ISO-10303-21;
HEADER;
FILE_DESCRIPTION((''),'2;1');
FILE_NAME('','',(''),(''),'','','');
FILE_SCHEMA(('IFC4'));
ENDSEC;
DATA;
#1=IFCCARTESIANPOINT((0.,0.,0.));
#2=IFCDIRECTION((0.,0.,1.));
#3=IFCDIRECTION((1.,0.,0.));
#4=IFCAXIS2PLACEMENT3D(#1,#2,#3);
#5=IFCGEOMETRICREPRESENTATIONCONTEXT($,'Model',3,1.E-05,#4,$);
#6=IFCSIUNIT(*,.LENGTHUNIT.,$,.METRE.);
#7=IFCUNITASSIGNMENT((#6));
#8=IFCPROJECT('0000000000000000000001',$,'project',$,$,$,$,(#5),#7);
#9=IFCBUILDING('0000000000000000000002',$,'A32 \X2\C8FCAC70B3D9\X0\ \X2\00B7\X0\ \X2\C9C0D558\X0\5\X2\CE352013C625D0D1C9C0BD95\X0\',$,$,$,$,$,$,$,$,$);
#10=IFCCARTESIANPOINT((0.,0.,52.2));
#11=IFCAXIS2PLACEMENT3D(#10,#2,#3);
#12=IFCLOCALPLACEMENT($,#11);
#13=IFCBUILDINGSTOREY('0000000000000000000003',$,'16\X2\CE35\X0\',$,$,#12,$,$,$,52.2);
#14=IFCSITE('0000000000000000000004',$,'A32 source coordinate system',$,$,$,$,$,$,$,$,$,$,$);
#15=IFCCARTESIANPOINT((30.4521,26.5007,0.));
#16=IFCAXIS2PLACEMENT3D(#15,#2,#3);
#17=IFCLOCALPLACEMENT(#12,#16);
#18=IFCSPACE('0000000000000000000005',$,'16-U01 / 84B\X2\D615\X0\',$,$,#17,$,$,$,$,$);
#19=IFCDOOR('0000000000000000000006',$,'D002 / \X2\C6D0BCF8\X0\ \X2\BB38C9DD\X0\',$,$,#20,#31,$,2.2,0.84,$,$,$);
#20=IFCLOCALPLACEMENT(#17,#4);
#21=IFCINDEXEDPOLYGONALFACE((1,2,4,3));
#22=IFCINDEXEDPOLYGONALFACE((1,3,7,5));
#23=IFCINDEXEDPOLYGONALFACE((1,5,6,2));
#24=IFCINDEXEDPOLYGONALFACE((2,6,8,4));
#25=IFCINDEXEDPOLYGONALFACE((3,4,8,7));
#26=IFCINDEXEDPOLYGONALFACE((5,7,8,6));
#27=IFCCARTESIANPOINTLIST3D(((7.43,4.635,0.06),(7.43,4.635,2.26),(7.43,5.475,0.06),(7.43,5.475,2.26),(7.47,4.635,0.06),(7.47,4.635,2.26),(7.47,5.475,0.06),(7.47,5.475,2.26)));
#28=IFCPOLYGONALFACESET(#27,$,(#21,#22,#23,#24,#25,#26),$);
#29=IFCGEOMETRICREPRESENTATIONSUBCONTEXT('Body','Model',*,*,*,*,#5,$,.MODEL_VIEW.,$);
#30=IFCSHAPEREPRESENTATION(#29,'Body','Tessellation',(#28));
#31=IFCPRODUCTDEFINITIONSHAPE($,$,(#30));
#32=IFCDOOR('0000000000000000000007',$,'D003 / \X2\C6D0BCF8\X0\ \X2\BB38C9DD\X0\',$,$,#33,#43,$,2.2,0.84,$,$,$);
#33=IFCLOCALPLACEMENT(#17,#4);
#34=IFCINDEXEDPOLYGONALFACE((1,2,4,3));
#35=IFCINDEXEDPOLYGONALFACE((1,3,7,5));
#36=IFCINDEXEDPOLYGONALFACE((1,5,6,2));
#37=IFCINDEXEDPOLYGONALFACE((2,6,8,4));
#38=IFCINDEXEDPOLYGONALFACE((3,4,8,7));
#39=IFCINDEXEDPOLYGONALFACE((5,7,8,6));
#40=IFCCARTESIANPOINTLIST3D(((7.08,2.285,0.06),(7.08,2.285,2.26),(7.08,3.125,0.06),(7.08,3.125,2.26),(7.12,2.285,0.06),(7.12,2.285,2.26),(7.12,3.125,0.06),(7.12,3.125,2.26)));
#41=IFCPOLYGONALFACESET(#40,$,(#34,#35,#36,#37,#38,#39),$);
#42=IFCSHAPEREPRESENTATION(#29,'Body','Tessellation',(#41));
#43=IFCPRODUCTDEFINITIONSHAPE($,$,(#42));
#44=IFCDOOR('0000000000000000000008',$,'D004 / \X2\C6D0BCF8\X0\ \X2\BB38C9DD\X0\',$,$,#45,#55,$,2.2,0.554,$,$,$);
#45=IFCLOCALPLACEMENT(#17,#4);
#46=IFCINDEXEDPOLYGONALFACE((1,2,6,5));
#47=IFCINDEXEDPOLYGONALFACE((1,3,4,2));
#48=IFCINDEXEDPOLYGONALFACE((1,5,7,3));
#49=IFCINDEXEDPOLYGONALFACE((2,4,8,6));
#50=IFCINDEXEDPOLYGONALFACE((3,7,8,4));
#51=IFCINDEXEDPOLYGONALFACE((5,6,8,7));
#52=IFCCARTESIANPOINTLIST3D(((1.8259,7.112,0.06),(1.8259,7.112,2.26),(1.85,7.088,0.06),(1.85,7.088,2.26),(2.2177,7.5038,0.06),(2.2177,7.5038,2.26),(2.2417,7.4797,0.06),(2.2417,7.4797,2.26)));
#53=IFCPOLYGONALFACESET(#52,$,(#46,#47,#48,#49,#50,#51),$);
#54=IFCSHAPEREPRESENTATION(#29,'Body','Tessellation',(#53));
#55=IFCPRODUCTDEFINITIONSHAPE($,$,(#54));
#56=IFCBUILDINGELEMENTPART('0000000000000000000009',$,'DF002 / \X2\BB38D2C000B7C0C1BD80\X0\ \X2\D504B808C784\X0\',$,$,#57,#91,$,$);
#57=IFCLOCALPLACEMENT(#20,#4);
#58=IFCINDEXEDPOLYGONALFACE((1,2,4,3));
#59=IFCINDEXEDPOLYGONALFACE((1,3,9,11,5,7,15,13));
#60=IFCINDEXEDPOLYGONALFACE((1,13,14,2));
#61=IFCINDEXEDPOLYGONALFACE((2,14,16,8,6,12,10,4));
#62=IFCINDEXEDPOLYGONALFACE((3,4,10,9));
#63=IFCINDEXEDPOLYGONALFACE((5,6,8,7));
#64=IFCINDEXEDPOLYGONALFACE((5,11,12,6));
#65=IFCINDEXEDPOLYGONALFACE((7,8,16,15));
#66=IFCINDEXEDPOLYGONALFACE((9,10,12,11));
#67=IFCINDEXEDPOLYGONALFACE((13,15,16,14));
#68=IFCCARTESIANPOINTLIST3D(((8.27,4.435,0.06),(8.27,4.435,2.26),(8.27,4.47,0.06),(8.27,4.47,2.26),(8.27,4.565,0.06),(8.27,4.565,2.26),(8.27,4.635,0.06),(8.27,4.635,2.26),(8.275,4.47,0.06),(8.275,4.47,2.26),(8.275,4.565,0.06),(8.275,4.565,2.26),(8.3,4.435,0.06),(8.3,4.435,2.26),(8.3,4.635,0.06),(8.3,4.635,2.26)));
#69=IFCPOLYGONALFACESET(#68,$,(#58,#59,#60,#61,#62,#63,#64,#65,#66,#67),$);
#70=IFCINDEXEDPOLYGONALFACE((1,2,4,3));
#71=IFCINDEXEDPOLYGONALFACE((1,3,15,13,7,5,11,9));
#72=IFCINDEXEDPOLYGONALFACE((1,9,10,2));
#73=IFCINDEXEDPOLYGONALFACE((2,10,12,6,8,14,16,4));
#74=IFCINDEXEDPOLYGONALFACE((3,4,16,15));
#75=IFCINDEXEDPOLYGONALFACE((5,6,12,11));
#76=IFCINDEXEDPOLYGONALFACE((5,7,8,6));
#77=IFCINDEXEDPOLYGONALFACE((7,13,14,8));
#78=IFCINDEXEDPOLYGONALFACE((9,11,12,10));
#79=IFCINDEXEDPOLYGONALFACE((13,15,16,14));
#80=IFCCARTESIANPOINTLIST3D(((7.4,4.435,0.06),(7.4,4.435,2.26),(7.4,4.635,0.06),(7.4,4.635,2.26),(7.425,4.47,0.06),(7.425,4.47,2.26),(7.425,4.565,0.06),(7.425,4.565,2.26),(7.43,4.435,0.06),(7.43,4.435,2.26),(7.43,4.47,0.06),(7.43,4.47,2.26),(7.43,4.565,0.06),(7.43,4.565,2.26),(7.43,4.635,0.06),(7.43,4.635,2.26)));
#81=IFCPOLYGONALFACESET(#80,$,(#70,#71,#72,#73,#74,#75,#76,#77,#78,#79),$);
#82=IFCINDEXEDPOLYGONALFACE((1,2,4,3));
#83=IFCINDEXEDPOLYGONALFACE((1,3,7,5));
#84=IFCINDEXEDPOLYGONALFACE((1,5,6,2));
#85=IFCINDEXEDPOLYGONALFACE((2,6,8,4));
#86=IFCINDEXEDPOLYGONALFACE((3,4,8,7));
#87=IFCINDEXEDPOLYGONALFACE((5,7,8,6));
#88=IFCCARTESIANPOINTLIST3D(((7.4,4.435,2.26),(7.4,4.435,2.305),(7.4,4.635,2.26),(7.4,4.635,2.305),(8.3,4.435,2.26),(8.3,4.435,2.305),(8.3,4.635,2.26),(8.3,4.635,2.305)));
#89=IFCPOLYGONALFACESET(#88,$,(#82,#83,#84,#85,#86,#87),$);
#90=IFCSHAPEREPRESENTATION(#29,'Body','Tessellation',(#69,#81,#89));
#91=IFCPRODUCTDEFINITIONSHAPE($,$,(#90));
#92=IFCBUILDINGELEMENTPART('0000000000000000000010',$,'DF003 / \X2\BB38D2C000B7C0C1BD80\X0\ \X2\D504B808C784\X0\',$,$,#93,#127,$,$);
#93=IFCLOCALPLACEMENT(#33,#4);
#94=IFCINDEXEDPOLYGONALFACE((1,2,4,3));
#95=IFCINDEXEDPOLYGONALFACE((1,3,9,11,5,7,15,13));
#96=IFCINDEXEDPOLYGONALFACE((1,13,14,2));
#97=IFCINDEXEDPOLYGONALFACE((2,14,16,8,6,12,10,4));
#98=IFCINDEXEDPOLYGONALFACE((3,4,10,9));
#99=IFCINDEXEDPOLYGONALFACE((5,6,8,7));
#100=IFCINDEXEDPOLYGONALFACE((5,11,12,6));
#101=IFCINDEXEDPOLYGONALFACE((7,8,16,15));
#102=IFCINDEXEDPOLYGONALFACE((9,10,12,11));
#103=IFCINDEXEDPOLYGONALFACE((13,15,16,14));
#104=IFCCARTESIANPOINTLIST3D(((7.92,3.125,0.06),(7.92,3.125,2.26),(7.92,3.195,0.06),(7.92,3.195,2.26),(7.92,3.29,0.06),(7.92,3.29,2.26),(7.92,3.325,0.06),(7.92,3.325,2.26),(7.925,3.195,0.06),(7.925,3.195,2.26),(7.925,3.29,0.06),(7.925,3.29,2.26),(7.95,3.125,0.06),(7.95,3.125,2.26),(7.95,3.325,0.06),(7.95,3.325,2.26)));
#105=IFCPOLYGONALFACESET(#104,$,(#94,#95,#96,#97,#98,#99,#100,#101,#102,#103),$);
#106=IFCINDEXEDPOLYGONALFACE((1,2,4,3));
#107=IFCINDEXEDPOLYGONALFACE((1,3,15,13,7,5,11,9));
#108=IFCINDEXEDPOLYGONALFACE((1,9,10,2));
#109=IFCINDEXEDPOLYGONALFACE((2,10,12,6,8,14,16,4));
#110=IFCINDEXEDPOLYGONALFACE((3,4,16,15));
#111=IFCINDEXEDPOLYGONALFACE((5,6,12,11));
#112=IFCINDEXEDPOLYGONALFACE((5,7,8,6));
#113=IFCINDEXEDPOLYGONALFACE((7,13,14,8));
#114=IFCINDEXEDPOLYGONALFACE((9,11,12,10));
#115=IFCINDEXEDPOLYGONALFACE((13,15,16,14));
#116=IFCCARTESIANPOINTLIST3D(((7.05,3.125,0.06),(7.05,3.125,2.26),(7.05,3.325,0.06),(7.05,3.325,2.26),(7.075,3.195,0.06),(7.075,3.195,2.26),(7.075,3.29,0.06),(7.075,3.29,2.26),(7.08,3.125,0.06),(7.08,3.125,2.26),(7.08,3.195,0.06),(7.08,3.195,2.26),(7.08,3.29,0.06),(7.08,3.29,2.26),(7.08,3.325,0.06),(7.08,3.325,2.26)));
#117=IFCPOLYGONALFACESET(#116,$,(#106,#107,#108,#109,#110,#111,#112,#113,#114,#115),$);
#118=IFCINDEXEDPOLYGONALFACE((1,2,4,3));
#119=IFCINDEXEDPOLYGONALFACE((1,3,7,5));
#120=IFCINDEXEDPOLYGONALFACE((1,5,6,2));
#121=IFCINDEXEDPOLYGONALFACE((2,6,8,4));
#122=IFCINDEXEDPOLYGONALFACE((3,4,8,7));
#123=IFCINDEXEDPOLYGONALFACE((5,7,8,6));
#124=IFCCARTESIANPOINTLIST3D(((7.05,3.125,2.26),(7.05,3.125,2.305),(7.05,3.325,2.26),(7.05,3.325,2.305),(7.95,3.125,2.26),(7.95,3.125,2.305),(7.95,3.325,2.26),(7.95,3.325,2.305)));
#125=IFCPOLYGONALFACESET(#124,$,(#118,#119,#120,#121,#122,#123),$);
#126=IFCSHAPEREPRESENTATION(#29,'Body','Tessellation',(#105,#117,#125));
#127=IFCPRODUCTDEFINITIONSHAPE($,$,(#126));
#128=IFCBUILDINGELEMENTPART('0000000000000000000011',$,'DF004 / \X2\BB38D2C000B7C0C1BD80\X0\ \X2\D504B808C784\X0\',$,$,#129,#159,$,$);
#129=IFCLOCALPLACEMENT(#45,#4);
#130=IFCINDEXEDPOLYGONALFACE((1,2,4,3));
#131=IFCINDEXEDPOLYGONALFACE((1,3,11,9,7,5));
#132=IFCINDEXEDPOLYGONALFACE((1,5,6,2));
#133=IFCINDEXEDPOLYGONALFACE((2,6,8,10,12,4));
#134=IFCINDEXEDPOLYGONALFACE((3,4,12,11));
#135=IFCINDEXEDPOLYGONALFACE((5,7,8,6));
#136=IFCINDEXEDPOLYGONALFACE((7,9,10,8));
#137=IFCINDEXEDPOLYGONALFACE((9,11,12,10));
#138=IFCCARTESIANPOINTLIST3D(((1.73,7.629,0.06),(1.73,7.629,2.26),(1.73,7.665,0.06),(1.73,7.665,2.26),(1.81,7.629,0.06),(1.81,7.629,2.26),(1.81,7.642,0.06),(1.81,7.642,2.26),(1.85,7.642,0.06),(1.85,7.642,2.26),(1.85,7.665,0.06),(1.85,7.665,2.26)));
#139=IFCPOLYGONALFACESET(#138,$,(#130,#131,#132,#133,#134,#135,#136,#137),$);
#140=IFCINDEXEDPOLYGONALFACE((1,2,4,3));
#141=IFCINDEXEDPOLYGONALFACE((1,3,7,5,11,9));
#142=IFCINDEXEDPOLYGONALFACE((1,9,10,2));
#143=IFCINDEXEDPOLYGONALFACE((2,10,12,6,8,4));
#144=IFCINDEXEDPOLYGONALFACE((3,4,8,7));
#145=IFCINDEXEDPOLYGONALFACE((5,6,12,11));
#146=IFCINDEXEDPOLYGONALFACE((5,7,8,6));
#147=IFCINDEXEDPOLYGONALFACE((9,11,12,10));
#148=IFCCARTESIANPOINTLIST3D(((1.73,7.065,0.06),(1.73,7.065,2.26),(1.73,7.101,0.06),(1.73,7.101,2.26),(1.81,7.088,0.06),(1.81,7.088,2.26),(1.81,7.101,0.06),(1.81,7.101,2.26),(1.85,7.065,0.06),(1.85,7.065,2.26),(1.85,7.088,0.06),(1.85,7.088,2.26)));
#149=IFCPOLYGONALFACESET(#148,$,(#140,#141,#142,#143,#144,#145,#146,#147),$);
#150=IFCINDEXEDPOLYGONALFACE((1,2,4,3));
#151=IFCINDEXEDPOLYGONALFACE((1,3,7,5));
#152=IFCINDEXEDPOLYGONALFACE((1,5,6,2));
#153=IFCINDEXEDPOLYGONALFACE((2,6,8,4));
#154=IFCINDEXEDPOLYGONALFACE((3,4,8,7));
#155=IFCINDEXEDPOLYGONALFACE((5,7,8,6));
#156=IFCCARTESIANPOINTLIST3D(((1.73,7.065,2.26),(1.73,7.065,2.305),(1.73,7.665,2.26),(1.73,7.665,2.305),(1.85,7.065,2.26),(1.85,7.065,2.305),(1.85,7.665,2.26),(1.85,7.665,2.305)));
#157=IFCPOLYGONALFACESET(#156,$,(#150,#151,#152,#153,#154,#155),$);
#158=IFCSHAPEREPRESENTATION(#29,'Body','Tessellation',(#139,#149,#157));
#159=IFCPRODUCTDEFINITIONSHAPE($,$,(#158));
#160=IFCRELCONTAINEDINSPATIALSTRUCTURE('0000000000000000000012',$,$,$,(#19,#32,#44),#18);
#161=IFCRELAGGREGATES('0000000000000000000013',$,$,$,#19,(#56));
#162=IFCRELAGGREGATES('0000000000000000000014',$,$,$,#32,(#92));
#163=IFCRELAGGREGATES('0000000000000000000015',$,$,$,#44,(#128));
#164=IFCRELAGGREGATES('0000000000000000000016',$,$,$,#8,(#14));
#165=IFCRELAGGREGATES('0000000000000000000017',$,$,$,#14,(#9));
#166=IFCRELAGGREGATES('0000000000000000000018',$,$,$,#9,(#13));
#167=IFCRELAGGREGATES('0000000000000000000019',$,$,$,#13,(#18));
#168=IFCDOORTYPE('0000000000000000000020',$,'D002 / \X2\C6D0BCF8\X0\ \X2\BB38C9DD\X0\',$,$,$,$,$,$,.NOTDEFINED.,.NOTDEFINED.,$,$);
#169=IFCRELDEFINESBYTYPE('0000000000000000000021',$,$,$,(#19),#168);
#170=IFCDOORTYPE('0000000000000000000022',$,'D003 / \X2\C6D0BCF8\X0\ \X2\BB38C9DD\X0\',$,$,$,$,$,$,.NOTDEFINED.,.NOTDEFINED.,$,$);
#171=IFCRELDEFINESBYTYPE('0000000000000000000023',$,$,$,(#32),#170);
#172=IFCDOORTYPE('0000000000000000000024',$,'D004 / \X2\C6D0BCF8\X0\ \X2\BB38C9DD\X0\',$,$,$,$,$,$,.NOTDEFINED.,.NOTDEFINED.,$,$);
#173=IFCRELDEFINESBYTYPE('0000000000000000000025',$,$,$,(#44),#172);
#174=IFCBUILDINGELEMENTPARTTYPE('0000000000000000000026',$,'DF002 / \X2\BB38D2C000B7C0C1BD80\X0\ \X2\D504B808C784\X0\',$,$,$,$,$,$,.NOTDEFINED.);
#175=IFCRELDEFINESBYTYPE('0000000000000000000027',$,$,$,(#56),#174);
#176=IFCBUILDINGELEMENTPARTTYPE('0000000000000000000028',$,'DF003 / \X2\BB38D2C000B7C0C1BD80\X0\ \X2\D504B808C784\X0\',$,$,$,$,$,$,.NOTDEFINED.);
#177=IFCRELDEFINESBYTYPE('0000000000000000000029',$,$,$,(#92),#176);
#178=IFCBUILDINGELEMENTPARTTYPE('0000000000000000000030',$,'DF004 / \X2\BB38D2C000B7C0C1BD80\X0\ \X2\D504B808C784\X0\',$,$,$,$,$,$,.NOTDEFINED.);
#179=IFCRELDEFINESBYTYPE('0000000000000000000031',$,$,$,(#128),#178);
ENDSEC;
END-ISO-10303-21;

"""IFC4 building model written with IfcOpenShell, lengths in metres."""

from ifc_helpers import new_model, si_unit, frame, origin, origin_with_axes, place, context, subcontext, project, spatial, polyline, outline, extrude, source, transform, mapped, type_object, type_shapes, element, aggregate, save


model = new_model("IFC4")

# Units and contexts
model_context = context("Model", 3, precision=1e-05, world=origin_with_axes())
body_context = subcontext(model_context, "Body", "Model", "MODEL_VIEW")
ifc_project = project(units=[si_unit("LENGTHUNIT", "METRE")], contexts=[model_context])

# Site, building, storey, space
storey_placement = place(None, frame((0.0, 0.0, 52.2), z_axis=(0.0, 0.0, 1.0), x_axis=(1.0, 0.0, 0.0)))
space_placement = place(storey_placement, frame((30.4521, 26.5007, 0.0), z_axis=(0.0, 0.0, 1.0), x_axis=(1.0, 0.0, 0.0)))
site = spatial("IfcSite", under=ifc_project, Name="A32 source coordinate system")
building = spatial("IfcBuilding", under=site, Name="A32 주거동 · 지하5층–옥탑지붕")
storey = spatial("IfcBuildingStorey", under=building, at=storey_placement, Name="16층", Elevation=52.2)
space = spatial("IfcSpace", under=storey, at=space_placement, Name="16-U01 / 84B형")

# Doors
door_type_1 = type_object("IfcDoorType", Name="D002 / 원본 문짝", OperationType="NOTDEFINED", PredefinedType="NOTDEFINED")
shared_shape_1 = source(origin(), body_context, "Body", "SweptSolid", [
    extrude(outline(polyline([(7.43, 4.635), (7.43, 5.475), (7.47, 5.475), (7.47, 4.635), (7.43, 4.635)])), frame((0.0, 0.0, 0.06)), (0.0, 0.0, 1.0), 2.2),
])
type_shapes(door_type_1, [shared_shape_1])
door_1_placement = place(space_placement, origin_with_axes())
door_1 = element("IfcDoor", 1, at=door_1_placement, inside=space, type_object=door_type_1, Name="D002 / 원본 문짝", OverallHeight=2.2, OverallWidth=0.84, context=body_context, shape_type="MappedRepresentation", body=[
    mapped(shared_shape_1, transform((0.0, 0.0, 0.0), scale=1.0)),
])
door_type_2 = type_object("IfcDoorType", Name="D003 / 원본 문짝", OperationType="NOTDEFINED", PredefinedType="NOTDEFINED")
shared_shape_2 = source(origin(), body_context, "Body", "SweptSolid", [
    extrude(outline(polyline([(7.12, 2.285), (7.08, 2.285), (7.08, 3.125), (7.12, 3.125), (7.12, 2.285)])), frame((0.0, 0.0, 0.06)), (0.0, 0.0, 1.0), 2.2),
])
type_shapes(door_type_2, [shared_shape_2])
door_2_placement = place(space_placement, origin_with_axes())
door_2 = element("IfcDoor", 2, at=door_2_placement, inside=space, type_object=door_type_2, Name="D003 / 원본 문짝", OverallHeight=2.2, OverallWidth=0.84, context=body_context, shape_type="MappedRepresentation", body=[
    mapped(shared_shape_2, transform((0.0, 0.0, 0.0), scale=1.0)),
])
door_type_3 = type_object("IfcDoorType", Name="D004 / 원본 문짝", OperationType="NOTDEFINED", PredefinedType="NOTDEFINED")
shared_shape_3 = source(origin(), body_context, "Body", "SweptSolid", [
    extrude(outline(polyline([(2.2177, 7.5038), (2.2417, 7.4797), (1.85, 7.088), (1.8259, 7.112), (2.2177, 7.5038)])), frame((0.0, 0.0, 0.06)), (0.0, 0.0, 1.0), 2.2),
])
type_shapes(door_type_3, [shared_shape_3])
door_3_placement = place(space_placement, origin_with_axes())
door_3 = element("IfcDoor", 3, at=door_3_placement, inside=space, type_object=door_type_3, Name="D004 / 원본 문짝", OverallHeight=2.2, OverallWidth=0.554, context=body_context, shape_type="MappedRepresentation", body=[
    mapped(shared_shape_3, transform((0.0, 0.0, 0.0), scale=1.0)),
])

# Building element parts
building_element_part_type_1 = type_object("IfcBuildingElementPartType", Name="DF002 / 문틀·상부 프레임", PredefinedType="NOTDEFINED")
shared_shape_4 = source(origin(), body_context, "Body", "SweptSolid", [
    extrude(outline(polyline([(8.3, 4.435), (8.27, 4.435), (8.27, 4.47), (8.275, 4.47), (8.275, 4.565), (8.27, 4.565), (8.27, 4.635), (8.3, 4.635), (8.3, 4.435)])), frame((0.0, 0.0, 0.06)), (0.0, 0.0, 1.0), 2.2),
    extrude(outline(polyline([(7.43, 4.635), (7.43, 4.565), (7.425, 4.565), (7.425, 4.47), (7.43, 4.47), (7.43, 4.435), (7.4, 4.435), (7.4, 4.635), (7.43, 4.635)])), frame((0.0, 0.0, 0.06)), (0.0, 0.0, 1.0), 2.2),
    extrude(outline(polyline([(7.4, 4.435), (7.4, 4.635), (8.3, 4.635), (8.3, 4.435), (7.4, 4.435)])), frame((0.0, 0.0, 2.26)), (0.0, 0.0, 1.0), 0.045),
])
type_shapes(building_element_part_type_1, [shared_shape_4])
building_element_part_1_placement = place(door_1_placement, origin_with_axes())
building_element_part_1 = element("IfcBuildingElementPart", 4, at=building_element_part_1_placement, type_object=building_element_part_type_1, Name="DF002 / 문틀·상부 프레임", context=body_context, shape_type="MappedRepresentation", body=[
    mapped(shared_shape_4, transform((0.0, 0.0, 0.0), scale=1.0)),
])
aggregate(door_1, [building_element_part_1])
building_element_part_type_2 = type_object("IfcBuildingElementPartType", Name="DF003 / 문틀·상부 프레임", PredefinedType="NOTDEFINED")
shared_shape_5 = source(origin(), body_context, "Body", "SweptSolid", [
    extrude(outline(polyline([(7.92, 3.125), (7.92, 3.195), (7.925, 3.195), (7.925, 3.29), (7.92, 3.29), (7.92, 3.325), (7.95, 3.325), (7.95, 3.125), (7.92, 3.125)])), frame((0.0, 0.0, 0.06)), (0.0, 0.0, 1.0), 2.2),
    extrude(outline(polyline([(7.05, 3.325), (7.08, 3.325), (7.08, 3.29), (7.075, 3.29), (7.075, 3.195), (7.08, 3.195), (7.08, 3.125), (7.05, 3.125), (7.05, 3.325)])), frame((0.0, 0.0, 0.06)), (0.0, 0.0, 1.0), 2.2),
    extrude(outline(polyline([(7.05, 3.125), (7.05, 3.325), (7.95, 3.325), (7.95, 3.125), (7.05, 3.125)])), frame((0.0, 0.0, 2.26)), (0.0, 0.0, 1.0), 0.045),
])
type_shapes(building_element_part_type_2, [shared_shape_5])
building_element_part_2_placement = place(door_2_placement, origin_with_axes())
building_element_part_2 = element("IfcBuildingElementPart", 5, at=building_element_part_2_placement, type_object=building_element_part_type_2, Name="DF003 / 문틀·상부 프레임", context=body_context, shape_type="MappedRepresentation", body=[
    mapped(shared_shape_5, transform((0.0, 0.0, 0.0), scale=1.0)),
])
aggregate(door_2, [building_element_part_2])
building_element_part_type_3 = type_object("IfcBuildingElementPartType", Name="DF004 / 문틀·상부 프레임", PredefinedType="NOTDEFINED")
shared_shape_6 = source(origin(), body_context, "Body", "SweptSolid", [
    extrude(outline(polyline([(1.85, 7.665), (1.85, 7.642), (1.81, 7.642), (1.81, 7.629), (1.73, 7.629), (1.73, 7.665), (1.85, 7.665)])), frame((0.0, 0.0, 0.06)), (0.0, 0.0, 1.0), 2.2),
    extrude(outline(polyline([(1.73, 7.101), (1.81, 7.101), (1.81, 7.088), (1.85, 7.088), (1.85, 7.065), (1.73, 7.065), (1.73, 7.101)])), frame((0.0, 0.0, 0.06)), (0.0, 0.0, 1.0), 2.2),
    extrude(outline(polyline([(1.73, 7.065), (1.73, 7.665), (1.85, 7.665), (1.85, 7.065), (1.73, 7.065)])), frame((0.0, 0.0, 2.26)), (0.0, 0.0, 1.0), 0.045),
])
type_shapes(building_element_part_type_3, [shared_shape_6])
building_element_part_3_placement = place(door_3_placement, origin_with_axes())
building_element_part_3 = element("IfcBuildingElementPart", 6, at=building_element_part_3_placement, type_object=building_element_part_type_3, Name="DF004 / 문틀·상부 프레임", context=body_context, shape_type="MappedRepresentation", body=[
    mapped(shared_shape_6, transform((0.0, 0.0, 0.0), scale=1.0)),
])
aggregate(door_3, [building_element_part_3])

save(model, "model.ifc")
